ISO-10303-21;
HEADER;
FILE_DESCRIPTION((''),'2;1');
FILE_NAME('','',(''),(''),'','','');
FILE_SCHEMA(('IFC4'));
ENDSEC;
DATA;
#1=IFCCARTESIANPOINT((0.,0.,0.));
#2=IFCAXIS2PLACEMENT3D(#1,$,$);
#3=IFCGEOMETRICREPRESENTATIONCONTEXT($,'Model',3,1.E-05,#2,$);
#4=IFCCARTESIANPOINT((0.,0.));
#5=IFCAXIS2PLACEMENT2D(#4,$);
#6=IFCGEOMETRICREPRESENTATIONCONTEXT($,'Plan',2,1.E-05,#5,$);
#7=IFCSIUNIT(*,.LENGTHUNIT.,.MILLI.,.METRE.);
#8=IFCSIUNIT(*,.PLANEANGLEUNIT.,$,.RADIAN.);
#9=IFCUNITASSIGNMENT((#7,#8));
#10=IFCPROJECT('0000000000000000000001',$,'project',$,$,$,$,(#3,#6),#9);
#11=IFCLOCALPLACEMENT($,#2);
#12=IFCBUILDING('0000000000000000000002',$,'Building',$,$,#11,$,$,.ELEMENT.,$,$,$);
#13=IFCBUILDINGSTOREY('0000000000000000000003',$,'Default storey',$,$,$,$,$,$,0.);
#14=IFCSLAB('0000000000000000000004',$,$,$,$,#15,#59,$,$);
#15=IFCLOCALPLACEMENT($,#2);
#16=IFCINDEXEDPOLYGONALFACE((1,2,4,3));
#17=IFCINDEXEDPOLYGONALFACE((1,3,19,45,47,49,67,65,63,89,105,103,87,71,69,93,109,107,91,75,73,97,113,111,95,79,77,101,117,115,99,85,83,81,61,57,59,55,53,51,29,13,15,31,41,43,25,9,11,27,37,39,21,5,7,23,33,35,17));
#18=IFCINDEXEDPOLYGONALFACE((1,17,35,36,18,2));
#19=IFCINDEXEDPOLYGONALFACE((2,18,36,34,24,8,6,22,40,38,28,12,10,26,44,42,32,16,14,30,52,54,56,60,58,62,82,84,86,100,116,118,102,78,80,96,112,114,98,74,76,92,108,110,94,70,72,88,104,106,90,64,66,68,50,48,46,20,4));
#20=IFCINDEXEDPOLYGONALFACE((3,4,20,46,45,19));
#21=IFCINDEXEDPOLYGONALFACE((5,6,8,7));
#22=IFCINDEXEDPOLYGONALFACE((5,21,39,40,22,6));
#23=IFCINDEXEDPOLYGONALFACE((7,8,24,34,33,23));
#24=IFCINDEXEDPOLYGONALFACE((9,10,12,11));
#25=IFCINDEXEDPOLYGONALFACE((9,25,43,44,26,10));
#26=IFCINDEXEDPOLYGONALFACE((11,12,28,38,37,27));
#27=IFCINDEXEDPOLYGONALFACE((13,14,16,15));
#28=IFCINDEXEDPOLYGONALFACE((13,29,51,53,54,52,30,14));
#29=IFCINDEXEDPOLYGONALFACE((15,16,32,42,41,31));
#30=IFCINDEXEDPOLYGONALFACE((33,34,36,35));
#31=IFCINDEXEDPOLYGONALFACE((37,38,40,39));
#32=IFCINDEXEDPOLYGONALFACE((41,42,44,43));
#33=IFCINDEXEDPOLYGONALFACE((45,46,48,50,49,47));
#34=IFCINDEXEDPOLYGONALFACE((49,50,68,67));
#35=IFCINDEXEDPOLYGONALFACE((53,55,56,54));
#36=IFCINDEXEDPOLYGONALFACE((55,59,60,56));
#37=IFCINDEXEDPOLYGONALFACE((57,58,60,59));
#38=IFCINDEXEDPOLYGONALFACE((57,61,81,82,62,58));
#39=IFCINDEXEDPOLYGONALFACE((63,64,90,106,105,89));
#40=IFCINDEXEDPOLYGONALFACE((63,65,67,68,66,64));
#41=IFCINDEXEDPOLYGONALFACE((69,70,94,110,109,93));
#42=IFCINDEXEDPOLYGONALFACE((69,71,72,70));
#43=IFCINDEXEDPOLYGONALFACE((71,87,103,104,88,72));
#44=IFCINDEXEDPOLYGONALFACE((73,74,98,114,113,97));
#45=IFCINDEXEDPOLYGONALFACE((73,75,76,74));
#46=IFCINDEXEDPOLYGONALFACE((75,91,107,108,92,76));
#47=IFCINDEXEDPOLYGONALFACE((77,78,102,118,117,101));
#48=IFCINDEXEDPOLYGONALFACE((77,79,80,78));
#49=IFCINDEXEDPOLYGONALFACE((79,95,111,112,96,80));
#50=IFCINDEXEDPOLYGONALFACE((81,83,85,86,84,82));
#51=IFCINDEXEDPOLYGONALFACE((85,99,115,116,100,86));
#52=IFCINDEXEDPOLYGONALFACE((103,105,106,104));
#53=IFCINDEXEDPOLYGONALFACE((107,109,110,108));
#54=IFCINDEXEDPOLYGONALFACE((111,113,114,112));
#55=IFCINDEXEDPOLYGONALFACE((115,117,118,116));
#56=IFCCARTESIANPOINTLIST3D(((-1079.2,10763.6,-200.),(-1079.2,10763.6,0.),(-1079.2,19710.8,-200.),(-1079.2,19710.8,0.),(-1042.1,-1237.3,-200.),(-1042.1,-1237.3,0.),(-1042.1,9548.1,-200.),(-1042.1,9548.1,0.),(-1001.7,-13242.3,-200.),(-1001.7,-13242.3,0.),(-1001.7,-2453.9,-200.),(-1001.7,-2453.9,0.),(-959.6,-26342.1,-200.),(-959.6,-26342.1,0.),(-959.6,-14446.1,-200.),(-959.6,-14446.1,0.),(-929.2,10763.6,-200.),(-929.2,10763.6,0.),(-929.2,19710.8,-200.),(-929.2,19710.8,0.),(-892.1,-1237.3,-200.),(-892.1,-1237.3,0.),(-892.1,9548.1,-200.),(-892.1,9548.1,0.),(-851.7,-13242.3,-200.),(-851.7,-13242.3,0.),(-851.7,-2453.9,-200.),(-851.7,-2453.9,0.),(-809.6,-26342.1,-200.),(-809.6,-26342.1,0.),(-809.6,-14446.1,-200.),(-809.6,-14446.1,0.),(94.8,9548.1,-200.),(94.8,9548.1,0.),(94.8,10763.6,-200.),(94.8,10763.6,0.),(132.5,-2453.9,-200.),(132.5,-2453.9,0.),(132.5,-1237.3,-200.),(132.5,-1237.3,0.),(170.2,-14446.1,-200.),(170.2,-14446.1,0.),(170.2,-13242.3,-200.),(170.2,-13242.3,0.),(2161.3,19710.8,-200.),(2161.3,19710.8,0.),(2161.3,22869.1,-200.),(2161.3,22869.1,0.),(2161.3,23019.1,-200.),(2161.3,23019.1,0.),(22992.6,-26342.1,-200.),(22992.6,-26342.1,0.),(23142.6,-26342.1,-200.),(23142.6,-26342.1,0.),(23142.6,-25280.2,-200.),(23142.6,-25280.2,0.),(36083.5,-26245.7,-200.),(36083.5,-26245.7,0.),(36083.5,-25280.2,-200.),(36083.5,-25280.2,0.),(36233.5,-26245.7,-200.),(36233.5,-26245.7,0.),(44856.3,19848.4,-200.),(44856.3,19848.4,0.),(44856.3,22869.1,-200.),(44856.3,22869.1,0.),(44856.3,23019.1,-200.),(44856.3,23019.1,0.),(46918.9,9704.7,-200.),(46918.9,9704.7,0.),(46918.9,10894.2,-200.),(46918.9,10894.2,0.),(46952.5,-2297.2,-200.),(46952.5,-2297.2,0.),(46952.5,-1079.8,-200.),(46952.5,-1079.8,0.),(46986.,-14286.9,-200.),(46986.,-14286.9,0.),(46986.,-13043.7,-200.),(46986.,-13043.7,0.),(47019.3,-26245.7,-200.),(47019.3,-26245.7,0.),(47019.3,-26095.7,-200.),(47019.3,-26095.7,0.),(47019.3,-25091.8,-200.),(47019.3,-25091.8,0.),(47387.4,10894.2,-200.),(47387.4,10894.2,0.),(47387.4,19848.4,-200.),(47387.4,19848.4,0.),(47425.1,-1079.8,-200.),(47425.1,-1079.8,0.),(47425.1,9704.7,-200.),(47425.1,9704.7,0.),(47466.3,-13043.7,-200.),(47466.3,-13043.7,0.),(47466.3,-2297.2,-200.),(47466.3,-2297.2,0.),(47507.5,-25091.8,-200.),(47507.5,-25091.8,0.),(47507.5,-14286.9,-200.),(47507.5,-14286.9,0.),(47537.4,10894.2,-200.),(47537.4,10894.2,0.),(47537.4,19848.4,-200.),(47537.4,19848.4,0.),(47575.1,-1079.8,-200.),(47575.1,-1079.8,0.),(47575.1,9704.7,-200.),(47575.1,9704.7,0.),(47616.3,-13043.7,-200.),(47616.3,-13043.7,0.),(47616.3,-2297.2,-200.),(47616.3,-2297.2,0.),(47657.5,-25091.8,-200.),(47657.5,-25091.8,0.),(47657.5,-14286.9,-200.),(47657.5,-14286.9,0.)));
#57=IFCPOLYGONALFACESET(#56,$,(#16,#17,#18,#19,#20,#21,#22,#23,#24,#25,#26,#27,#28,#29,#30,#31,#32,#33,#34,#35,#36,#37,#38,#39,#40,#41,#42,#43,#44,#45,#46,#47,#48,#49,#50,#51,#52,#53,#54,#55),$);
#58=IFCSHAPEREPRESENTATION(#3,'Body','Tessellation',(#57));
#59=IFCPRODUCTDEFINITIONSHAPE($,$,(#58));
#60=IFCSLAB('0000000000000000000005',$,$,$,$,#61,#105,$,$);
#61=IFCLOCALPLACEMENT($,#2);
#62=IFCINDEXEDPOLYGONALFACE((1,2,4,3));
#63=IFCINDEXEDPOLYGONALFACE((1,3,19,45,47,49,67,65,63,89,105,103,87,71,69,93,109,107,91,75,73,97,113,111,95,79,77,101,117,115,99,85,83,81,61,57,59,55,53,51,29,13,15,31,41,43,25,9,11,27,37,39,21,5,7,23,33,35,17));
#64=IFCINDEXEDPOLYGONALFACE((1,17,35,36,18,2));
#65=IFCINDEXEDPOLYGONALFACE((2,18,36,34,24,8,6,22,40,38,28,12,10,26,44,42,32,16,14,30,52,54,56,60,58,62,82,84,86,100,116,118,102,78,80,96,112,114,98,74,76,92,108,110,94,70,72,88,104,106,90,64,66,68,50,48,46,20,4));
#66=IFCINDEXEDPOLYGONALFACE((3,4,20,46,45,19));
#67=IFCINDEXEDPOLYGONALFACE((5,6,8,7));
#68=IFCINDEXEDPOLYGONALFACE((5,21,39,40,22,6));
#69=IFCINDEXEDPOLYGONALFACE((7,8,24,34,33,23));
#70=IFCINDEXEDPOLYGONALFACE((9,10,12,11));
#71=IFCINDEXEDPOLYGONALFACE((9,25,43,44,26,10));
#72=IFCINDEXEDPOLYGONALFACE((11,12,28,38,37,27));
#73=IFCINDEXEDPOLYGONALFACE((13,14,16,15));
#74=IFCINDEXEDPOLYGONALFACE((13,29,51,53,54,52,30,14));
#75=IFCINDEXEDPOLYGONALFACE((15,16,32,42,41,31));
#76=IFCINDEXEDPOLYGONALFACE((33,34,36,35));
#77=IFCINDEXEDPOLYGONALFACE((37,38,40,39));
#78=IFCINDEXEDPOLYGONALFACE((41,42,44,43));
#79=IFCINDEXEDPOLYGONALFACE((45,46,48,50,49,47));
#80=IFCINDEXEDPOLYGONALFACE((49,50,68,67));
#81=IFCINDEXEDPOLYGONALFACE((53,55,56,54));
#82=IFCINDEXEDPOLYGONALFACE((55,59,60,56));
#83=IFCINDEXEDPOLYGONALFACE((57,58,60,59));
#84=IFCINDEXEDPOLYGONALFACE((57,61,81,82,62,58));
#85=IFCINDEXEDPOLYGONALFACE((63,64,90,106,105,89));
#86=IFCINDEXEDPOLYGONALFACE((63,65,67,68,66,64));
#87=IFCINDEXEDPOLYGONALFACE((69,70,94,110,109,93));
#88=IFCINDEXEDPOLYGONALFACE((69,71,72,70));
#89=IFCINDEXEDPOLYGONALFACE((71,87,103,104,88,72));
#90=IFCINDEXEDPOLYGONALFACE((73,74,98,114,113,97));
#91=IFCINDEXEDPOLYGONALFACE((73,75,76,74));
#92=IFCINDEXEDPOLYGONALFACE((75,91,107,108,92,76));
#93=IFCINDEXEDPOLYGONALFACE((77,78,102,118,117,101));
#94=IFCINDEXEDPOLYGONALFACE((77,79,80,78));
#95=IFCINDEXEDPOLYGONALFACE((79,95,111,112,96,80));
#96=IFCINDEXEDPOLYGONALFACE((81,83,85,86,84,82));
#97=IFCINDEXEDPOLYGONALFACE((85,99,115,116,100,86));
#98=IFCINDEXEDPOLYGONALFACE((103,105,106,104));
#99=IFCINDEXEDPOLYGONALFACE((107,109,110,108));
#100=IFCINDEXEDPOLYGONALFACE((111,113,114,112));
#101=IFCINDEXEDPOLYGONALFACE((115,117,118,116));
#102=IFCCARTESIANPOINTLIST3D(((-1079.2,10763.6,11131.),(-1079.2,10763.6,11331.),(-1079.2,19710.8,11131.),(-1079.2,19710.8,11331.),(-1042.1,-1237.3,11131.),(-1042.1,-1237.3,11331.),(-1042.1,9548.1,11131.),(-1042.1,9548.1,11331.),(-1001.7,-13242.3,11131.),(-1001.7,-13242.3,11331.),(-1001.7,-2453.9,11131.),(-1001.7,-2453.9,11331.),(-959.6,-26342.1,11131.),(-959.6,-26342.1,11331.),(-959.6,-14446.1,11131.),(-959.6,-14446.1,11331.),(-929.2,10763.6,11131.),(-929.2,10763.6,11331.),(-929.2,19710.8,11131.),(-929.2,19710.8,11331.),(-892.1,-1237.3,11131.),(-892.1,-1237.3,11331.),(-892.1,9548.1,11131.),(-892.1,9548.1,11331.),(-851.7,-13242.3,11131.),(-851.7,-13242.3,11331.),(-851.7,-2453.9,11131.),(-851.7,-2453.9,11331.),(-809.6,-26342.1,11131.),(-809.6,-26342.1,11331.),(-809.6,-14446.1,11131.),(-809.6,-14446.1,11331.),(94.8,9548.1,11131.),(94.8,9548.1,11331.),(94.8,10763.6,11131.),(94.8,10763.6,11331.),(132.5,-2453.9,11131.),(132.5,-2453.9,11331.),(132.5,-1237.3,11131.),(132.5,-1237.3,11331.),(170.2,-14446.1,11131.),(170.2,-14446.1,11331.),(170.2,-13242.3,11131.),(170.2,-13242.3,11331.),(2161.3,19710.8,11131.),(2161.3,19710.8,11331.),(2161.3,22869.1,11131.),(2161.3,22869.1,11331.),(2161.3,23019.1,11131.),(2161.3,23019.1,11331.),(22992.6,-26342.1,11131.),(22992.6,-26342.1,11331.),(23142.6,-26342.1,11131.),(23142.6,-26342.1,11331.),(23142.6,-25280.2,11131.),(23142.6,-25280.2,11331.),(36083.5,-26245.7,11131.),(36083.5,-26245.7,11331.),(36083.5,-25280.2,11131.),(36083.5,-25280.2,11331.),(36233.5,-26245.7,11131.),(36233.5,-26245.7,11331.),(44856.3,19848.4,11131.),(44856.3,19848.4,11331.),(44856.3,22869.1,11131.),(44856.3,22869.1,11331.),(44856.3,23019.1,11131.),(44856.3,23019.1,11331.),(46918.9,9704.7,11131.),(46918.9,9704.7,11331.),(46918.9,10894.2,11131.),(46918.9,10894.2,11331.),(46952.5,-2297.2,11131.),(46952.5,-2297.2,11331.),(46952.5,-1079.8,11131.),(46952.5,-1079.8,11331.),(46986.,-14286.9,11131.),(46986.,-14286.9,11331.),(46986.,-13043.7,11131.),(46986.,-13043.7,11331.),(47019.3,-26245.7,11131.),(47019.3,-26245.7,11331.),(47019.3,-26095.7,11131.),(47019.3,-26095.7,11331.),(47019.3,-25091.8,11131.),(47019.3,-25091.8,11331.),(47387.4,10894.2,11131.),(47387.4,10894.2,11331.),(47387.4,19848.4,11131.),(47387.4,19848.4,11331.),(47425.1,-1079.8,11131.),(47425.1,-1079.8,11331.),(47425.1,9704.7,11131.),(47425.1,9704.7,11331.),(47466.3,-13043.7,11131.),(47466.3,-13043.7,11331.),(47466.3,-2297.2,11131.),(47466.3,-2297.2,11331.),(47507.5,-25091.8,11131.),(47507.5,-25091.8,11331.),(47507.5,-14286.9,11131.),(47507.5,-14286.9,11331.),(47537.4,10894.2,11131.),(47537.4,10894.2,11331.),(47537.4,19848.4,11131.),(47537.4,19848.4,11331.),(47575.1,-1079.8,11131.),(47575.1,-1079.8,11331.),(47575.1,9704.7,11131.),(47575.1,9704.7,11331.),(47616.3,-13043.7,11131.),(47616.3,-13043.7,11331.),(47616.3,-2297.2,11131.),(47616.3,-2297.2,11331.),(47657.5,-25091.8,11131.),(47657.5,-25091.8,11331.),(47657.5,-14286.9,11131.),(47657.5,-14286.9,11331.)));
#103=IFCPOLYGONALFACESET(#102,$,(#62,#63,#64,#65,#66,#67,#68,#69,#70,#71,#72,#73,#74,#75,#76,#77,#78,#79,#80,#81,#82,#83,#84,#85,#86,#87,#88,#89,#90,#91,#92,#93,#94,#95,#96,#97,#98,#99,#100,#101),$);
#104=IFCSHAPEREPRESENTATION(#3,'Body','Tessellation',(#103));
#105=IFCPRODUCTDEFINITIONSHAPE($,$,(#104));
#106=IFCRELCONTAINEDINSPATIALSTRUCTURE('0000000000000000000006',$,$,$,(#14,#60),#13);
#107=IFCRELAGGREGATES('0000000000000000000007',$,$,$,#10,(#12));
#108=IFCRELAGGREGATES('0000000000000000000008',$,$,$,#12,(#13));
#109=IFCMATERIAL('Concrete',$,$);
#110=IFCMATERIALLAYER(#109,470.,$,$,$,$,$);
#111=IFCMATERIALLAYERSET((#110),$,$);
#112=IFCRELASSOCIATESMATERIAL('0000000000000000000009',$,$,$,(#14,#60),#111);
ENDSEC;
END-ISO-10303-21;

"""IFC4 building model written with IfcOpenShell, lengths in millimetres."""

from ifc_helpers import new_model, si_unit, frame, origin, origin_2d, place, context, project, spatial, polyline, outline, extrude, material, layer, layer_set, layer_usage, element, save


model = new_model("IFC4")

# Units and contexts
model_context = context("Model", 3, precision=1e-05, world=origin())
plan_context = context("Plan", 2, precision=1e-05, world=origin_2d())
ifc_project = project(units=[si_unit("LENGTHUNIT", "METRE", prefix="MILLI"), si_unit("PLANEANGLEUNIT", "RADIAN")], contexts=[model_context, plan_context])

# Building, storey
placement = place(None, origin())
building = spatial("IfcBuilding", under=ifc_project, at=placement, Name="Building", CompositionType="ELEMENT")
storey = spatial("IfcBuildingStorey", under=building, Name="Default storey", Elevation=0.0)

# Slabs
ifc_material_1 = material(Name="Concrete")
ifc_layer = layer(ifc_material_1, 470.0)
ifc_layer_set = layer_set([ifc_layer])
ifc_layer_usage = layer_usage(ifc_layer_set, "AXIS3", "POSITIVE", 0.0)
element("IfcSlab", 1, at=placement, inside=storey, material=ifc_layer_usage, context=model_context, shape_type="SweptSolid", body=[
    extrude(outline(polyline([(46986.0, -14286.9), (46986.0, -13043.7), (47466.3, -13043.7), (47616.3, -13043.7), (47616.3, -2297.2), (47466.3, -2297.2), (46952.5, -2297.2), (46952.5, -1079.8), (47425.1, -1079.8), (47575.1, -1079.8), (47575.1, 9704.7), (47425.1, 9704.7), (46918.9, 9704.7), (46918.9, 10894.2), (47387.4, 10894.2), (47537.4, 10894.2), (47537.4, 19848.4), (47387.4, 19848.4), (44856.3, 19848.4), (44856.3, 22869.1), (44856.3, 23019.1), (2161.3, 23019.1), (2161.3, 22869.1), (2161.3, 19710.8), (-929.2, 19710.8), (-1079.2, 19710.8), (-1079.2, 10763.6), (-929.2, 10763.6), (94.8, 10763.6), (94.8, 9548.1), (-892.1, 9548.1), (-1042.1, 9548.1), (-1042.1, -1237.3), (-892.1, -1237.3), (132.5, -1237.3), (132.5, -2453.9), (-851.7, -2453.9), (-1001.7, -2453.9), (-1001.7, -13242.3), (-851.7, -13242.3), (170.2, -13242.3), (170.2, -14446.1), (-809.6, -14446.1), (-959.6, -14446.1), (-959.6, -26342.1), (-809.6, -26342.1), (22992.6, -26342.1), (23142.6, -26342.1), (23142.6, -25280.2), (36083.5, -25280.2), (36083.5, -26245.7), (36233.5, -26245.7), (47019.3, -26245.7), (47019.3, -26095.7), (47019.3, -25091.8), (47507.5, -25091.8), (47657.5, -25091.8), (47657.5, -14286.9), (47507.5, -14286.9), (46986.0, -14286.9)])), frame((0.0, 0.0, -200.0), z_axis=(0.0, 0.0, 1000.0), x_axis=(1000.0, 0.0, 0.0)), (0.0, 0.0, 1.0), 200.0),
])
element("IfcSlab", 2, at=placement, inside=storey, material=ifc_layer_usage, context=model_context, shape_type="SweptSolid", body=[
    extrude(outline(polyline([(46986.0, -14286.9), (46986.0, -13043.7), (47466.3, -13043.7), (47616.3, -13043.7), (47616.3, -2297.2), (47466.3, -2297.2), (46952.5, -2297.2), (46952.5, -1079.8), (47425.1, -1079.8), (47575.1, -1079.8), (47575.1, 9704.7), (47425.1, 9704.7), (46918.9, 9704.7), (46918.9, 10894.2), (47387.4, 10894.2), (47537.4, 10894.2), (47537.4, 19848.4), (47387.4, 19848.4), (44856.3, 19848.4), (44856.3, 22869.1), (44856.3, 23019.1), (2161.3, 23019.1), (2161.3, 22869.1), (2161.3, 19710.8), (-929.2, 19710.8), (-1079.2, 19710.8), (-1079.2, 10763.6), (-929.2, 10763.6), (94.8, 10763.6), (94.8, 9548.1), (-892.1, 9548.1), (-1042.1, 9548.1), (-1042.1, -1237.3), (-892.1, -1237.3), (132.5, -1237.3), (132.5, -2453.9), (-851.7, -2453.9), (-1001.7, -2453.9), (-1001.7, -13242.3), (-851.7, -13242.3), (170.2, -13242.3), (170.2, -14446.1), (-809.6, -14446.1), (-959.6, -14446.1), (-959.6, -26342.1), (-809.6, -26342.1), (22992.6, -26342.1), (23142.6, -26342.1), (23142.6, -25280.2), (36083.5, -25280.2), (36083.5, -26245.7), (36233.5, -26245.7), (47019.3, -26245.7), (47019.3, -26095.7), (47019.3, -25091.8), (47507.5, -25091.8), (47657.5, -25091.8), (47657.5, -14286.9), (47507.5, -14286.9), (46986.0, -14286.9)])), frame((0.0, 0.0, 11331.0), z_axis=(0.0, 0.0, 1000.0), x_axis=(1000.0, 0.0, 0.0)), (0.0, 0.0, -1.0), 200.0),
])

save(model, "model.ifc")
